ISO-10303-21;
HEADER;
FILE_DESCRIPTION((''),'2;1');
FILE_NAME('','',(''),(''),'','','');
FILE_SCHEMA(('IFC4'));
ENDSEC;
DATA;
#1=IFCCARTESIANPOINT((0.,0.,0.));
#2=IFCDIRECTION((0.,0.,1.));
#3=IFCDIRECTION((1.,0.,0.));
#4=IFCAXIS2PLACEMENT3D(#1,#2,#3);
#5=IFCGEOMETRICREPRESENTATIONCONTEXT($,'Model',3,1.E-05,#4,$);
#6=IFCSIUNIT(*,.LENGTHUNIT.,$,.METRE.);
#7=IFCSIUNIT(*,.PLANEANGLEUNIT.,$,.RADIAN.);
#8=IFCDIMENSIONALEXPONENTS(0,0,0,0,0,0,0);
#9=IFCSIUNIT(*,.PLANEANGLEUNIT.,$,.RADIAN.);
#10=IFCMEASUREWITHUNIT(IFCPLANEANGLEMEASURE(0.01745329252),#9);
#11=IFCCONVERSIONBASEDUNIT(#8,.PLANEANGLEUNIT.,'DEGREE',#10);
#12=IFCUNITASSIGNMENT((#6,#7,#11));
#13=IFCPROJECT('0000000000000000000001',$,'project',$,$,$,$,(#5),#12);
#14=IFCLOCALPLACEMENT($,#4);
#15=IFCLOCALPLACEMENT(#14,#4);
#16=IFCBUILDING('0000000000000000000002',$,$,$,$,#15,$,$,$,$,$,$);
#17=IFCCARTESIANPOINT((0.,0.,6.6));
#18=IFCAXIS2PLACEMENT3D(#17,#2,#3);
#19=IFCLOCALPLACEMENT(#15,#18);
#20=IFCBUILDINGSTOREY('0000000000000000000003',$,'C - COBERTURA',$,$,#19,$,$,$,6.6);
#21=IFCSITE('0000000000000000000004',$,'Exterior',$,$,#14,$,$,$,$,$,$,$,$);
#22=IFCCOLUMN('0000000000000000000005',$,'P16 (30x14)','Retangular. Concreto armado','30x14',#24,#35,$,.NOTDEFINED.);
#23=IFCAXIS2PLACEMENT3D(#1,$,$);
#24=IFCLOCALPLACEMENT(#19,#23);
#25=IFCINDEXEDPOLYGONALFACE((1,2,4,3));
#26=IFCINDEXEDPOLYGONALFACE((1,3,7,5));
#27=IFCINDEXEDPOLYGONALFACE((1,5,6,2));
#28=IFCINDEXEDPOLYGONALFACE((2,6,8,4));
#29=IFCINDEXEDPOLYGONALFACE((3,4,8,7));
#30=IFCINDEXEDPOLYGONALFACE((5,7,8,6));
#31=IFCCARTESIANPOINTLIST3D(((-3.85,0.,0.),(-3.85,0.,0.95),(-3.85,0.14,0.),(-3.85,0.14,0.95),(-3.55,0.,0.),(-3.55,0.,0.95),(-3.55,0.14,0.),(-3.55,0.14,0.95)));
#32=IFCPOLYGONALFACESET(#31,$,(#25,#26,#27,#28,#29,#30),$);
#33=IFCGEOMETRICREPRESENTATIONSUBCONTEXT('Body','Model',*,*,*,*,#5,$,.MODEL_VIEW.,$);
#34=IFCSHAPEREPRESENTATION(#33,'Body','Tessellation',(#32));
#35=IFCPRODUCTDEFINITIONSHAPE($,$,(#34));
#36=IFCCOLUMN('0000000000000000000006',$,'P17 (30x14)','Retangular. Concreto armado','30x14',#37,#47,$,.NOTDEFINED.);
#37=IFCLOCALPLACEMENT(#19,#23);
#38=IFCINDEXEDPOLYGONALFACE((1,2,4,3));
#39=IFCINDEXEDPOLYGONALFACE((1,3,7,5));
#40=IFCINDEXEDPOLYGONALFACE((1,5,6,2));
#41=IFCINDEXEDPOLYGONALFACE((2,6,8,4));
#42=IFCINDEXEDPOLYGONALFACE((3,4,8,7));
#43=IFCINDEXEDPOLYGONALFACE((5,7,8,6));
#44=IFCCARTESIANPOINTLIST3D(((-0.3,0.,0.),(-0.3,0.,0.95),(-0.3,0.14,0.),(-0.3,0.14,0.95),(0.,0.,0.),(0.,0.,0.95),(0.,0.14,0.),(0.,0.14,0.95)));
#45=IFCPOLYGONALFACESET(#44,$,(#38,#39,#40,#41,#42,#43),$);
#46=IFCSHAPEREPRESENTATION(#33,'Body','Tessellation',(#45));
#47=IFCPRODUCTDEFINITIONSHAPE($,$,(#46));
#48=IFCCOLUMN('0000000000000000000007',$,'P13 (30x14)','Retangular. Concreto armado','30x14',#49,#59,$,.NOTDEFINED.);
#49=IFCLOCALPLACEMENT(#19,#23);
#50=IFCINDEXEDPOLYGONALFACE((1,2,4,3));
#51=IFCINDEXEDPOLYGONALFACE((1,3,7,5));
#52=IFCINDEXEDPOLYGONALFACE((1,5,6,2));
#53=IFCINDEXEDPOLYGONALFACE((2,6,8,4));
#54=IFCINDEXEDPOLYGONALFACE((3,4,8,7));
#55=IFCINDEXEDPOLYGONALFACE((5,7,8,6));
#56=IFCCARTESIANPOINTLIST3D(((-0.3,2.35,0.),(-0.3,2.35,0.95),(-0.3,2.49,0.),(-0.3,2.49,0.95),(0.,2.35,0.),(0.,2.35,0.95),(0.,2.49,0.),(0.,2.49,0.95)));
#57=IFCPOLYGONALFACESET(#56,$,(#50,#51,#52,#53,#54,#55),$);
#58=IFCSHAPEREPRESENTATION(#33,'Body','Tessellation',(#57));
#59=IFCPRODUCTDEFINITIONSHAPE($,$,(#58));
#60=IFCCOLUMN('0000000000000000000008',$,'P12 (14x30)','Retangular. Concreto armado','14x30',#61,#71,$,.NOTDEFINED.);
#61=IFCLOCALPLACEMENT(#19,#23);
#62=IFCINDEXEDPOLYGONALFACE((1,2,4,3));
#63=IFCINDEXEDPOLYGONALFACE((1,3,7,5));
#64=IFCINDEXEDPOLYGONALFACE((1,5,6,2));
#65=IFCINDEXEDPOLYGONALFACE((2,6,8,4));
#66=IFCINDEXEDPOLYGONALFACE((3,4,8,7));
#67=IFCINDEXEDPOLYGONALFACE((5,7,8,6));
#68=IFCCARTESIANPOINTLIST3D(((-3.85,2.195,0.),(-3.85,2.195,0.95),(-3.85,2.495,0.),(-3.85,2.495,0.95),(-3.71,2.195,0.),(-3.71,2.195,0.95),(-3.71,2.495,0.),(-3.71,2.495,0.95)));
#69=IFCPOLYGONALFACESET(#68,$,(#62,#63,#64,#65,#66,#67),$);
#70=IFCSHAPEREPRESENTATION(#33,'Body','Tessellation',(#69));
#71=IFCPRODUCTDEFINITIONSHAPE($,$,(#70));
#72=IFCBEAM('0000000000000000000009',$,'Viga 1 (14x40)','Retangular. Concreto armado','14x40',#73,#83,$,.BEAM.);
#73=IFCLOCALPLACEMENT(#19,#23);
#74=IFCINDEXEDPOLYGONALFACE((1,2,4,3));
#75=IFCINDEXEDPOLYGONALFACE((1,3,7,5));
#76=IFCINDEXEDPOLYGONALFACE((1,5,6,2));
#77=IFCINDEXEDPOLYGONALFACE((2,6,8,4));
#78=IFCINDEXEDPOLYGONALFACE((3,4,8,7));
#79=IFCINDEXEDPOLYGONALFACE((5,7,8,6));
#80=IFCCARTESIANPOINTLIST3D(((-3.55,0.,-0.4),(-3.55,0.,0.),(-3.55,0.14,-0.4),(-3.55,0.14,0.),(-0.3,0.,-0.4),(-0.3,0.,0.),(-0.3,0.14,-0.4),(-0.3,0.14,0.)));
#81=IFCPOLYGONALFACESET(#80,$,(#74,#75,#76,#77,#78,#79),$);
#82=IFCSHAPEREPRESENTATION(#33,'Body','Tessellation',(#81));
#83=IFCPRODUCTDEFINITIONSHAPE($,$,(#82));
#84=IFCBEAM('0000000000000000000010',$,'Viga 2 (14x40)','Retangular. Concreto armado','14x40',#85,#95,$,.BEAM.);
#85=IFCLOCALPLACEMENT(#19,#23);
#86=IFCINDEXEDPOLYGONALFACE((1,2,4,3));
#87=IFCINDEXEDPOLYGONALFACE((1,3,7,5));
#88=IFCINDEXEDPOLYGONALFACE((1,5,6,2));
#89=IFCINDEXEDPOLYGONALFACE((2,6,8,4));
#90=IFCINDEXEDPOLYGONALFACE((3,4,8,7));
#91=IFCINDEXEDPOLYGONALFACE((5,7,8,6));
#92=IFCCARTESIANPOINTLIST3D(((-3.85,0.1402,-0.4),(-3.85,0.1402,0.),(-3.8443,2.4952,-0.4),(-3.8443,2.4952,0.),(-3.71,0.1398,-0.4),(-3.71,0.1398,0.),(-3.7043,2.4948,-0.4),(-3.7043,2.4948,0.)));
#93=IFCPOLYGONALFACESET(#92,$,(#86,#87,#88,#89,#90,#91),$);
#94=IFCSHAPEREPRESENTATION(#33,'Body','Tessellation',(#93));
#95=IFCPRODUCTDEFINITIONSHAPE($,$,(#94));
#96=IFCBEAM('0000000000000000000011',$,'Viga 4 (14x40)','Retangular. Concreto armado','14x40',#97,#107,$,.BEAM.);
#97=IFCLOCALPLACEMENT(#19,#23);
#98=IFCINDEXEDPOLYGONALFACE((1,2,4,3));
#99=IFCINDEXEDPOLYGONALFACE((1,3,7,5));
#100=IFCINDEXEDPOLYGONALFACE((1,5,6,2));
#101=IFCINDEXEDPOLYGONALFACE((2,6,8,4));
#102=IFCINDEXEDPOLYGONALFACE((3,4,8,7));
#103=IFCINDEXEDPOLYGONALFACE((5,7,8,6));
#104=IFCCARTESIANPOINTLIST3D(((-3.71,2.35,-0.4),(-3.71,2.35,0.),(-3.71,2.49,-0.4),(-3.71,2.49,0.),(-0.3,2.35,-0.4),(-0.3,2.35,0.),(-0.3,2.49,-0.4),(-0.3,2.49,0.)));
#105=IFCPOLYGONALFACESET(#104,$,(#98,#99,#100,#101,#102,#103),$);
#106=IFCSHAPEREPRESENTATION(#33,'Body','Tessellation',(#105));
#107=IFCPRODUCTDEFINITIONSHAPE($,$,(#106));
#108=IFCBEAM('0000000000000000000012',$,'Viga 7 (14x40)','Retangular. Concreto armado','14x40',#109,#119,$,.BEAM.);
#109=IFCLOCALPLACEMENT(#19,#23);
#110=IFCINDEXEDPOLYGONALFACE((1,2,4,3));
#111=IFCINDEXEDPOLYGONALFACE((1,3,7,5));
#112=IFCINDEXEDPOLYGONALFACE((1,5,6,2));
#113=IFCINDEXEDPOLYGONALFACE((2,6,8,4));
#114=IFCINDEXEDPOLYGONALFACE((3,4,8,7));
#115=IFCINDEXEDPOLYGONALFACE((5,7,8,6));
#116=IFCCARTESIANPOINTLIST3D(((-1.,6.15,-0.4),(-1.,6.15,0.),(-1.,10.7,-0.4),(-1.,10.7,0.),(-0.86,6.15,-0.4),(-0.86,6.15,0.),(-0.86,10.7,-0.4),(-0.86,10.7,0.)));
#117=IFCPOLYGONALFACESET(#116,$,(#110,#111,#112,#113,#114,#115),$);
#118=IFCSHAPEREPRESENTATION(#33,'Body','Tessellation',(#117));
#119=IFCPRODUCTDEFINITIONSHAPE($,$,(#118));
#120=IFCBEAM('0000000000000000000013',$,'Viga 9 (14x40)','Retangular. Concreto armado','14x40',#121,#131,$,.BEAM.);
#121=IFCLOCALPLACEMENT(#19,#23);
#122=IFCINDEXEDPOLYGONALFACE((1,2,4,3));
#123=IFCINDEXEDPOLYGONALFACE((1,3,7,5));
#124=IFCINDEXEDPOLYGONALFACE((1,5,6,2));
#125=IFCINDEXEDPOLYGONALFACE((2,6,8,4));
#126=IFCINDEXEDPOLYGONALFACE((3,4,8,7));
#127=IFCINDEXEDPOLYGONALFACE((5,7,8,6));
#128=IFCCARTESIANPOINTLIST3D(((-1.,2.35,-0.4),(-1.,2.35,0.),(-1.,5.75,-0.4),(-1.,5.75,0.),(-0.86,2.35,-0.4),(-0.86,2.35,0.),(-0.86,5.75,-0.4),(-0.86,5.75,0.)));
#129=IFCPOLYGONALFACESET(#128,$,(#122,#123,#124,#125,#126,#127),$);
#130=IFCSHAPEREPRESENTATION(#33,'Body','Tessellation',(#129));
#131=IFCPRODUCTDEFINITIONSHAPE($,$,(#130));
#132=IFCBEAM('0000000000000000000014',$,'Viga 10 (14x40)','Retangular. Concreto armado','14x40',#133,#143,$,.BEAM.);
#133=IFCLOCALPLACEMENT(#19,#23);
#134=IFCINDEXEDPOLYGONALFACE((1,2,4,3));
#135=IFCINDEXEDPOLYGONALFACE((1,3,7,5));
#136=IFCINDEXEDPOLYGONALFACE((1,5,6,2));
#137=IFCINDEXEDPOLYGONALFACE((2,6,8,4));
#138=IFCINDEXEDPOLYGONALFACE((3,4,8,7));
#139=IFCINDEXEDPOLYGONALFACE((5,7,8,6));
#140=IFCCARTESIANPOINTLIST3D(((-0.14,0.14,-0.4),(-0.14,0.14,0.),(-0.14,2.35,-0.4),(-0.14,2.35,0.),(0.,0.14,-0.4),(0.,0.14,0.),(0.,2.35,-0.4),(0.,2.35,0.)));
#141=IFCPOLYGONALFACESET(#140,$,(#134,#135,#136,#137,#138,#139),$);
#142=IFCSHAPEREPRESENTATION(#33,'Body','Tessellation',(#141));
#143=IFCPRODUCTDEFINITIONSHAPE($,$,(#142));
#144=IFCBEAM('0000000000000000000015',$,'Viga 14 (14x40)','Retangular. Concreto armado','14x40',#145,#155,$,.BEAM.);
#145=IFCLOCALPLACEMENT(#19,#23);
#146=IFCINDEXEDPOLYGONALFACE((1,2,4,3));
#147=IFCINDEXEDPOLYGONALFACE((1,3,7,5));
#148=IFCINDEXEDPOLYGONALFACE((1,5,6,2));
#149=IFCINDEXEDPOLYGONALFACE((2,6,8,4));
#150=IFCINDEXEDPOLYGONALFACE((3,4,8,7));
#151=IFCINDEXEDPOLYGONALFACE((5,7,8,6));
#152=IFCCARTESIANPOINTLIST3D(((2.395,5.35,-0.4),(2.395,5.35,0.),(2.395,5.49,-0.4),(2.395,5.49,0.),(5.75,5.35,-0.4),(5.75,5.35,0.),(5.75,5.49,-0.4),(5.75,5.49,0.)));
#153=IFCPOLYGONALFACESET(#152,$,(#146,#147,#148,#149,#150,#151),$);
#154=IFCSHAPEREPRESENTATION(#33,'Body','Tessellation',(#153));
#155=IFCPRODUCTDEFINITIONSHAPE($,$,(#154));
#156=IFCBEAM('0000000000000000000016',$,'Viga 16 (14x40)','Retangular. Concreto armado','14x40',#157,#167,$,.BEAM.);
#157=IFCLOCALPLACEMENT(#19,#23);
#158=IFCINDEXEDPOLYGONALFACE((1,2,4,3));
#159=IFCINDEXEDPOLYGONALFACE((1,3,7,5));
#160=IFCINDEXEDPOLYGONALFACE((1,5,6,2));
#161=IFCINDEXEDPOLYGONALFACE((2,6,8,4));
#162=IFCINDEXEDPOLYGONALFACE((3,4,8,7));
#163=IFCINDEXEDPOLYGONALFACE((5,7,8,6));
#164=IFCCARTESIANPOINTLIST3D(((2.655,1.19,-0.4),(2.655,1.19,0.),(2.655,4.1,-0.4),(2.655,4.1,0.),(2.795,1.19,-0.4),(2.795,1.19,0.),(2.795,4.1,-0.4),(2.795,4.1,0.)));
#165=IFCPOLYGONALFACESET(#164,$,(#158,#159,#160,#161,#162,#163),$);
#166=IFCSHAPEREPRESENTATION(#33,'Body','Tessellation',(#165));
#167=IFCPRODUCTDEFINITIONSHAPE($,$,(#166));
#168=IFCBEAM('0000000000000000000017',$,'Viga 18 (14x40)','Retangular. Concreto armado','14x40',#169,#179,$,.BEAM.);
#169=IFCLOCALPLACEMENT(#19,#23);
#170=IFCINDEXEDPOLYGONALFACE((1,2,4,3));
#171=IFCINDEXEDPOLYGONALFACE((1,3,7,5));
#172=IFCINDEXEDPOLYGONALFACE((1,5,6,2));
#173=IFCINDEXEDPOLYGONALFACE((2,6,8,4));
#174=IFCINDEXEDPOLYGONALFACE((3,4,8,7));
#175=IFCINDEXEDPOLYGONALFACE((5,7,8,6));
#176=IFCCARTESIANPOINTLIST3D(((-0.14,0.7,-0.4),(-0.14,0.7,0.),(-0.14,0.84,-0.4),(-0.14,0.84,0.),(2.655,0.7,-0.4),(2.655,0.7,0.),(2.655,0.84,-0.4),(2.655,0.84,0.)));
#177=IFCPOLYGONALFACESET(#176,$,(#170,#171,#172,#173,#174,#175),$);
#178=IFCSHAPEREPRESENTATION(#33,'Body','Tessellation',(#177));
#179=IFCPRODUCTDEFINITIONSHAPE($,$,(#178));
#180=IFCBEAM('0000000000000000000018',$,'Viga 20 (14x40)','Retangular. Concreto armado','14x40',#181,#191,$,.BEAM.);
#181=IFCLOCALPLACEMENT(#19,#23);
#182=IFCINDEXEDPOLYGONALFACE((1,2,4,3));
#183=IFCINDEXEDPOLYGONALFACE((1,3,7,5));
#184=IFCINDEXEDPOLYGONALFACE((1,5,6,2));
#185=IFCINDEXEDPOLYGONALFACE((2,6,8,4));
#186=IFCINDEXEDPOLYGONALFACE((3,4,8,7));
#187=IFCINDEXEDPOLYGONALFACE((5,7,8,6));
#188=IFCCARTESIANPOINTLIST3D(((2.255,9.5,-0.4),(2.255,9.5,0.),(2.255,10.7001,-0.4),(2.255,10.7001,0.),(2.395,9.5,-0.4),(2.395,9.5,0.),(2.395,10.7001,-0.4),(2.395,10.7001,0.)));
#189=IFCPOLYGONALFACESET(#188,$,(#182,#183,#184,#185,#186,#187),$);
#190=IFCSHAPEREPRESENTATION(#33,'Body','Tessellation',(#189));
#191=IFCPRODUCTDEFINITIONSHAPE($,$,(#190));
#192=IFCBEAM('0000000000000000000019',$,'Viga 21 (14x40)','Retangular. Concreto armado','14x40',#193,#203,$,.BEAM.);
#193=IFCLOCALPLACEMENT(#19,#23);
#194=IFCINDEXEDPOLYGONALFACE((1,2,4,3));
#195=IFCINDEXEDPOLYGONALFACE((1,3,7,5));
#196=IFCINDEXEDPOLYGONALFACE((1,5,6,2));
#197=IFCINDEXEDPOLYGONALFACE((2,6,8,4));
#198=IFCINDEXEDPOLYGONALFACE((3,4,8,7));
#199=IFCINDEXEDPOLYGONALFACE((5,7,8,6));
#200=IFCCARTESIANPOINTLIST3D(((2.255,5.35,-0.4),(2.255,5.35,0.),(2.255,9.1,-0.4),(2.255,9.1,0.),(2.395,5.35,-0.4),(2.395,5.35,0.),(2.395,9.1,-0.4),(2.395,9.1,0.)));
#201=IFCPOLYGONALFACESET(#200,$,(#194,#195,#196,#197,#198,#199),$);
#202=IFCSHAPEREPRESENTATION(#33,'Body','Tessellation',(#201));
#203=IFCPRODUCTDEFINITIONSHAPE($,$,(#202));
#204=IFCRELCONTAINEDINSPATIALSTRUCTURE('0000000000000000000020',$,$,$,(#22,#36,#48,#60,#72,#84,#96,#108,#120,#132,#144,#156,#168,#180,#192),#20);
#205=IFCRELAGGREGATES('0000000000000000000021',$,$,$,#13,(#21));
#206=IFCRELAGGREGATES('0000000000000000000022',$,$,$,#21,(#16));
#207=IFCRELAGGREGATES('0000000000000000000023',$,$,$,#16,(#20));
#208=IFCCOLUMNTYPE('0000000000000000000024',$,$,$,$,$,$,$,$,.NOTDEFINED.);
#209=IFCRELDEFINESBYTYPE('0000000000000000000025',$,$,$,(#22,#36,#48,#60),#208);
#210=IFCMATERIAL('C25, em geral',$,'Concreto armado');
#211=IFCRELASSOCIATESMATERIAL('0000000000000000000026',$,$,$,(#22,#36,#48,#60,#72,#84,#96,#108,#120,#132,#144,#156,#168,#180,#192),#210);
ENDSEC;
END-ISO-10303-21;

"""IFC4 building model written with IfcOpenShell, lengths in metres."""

from ifc_helpers import new_model, entity, si_unit, converted_unit, frame, frame_2d, origin_with_axes, origin_2d_with_axis, place, context, subcontext, project, spatial, rectangle, extrude, material, type_object, element, save


model = new_model("IFC4")

# Units and contexts
model_context = context("Model", 3, precision=1e-05, world=origin_with_axes())
body_context = subcontext(model_context, "Body", "Model", "MODEL_VIEW")
ifc_project = project(units=[si_unit("LENGTHUNIT", "METRE"), si_unit("PLANEANGLEUNIT", "RADIAN"), converted_unit("PLANEANGLEUNIT", "DEGREE", entity("IfcPlaneAngleMeasure", 0.01745329252), si_unit("PLANEANGLEUNIT", "RADIAN"), dimensions=[0, 0, 0, 0, 0, 0, 0])], contexts=[model_context])

# Site, building, storey
site_placement = place(None, origin_with_axes())
site = spatial("IfcSite", under=ifc_project, at=site_placement, Name="Exterior")
building_placement = place(site_placement, origin_with_axes())
building = spatial("IfcBuilding", under=site, at=building_placement)
storey_placement = place(building_placement, frame((0.0, 0.0, 6.6), z_axis=(0.0, 0.0, 1.0), x_axis=(1.0, 0.0, 0.0)))
storey = spatial("IfcBuildingStorey", under=building, at=storey_placement, Name="C - COBERTURA", Elevation=6.6)

# Columns
ifc_material_1 = material(Name="C25, em geral", Category="Concreto armado")
column_type = type_object("IfcColumnType", PredefinedType="NOTDEFINED")
for number, where, z_axis, x_axis, name in (
    (1, (-3.7, 0.07, 0.0), (0.0, 0.0, 1.0), (1.0, 0.0, 0.0), "P16 (30x14)"),
    (2, (-0.15, 0.07, 0.0), (0.0, 0.0, 1.0), (1.0, 0.0, 0.0), "P17 (30x14)"),
    (3, (-0.15, 2.42, 0.0), (0.0, 0.0, 1.0), (1.0, 0.0, 0.0), "P13 (30x14)"),
):
    element("IfcColumn", number, at=place(storey_placement, frame(where, z_axis=z_axis, x_axis=x_axis)), inside=storey, type_object=column_type, material=ifc_material_1, Name=name, Description="Retangular. Concreto armado", ObjectType="30x14", PredefinedType="NOTDEFINED", context=body_context, shape_type="SweptSolid", body=[
        extrude(rectangle(XDim=0.3, YDim=0.14, at=origin_2d_with_axis()), origin_with_axes(), (0.0, 0.0, 1.0), 0.95),
    ])
column_placement = place(storey_placement, frame((-3.78, 2.345, 0.0), z_axis=(0.0, 0.0, 1.0), x_axis=(1.0, 0.0, 0.0)))
element("IfcColumn", 4, at=column_placement, inside=storey, type_object=column_type, material=ifc_material_1, Name="P12 (14x30)", Description="Retangular. Concreto armado", ObjectType="14x30", PredefinedType="NOTDEFINED", context=body_context, shape_type="SweptSolid", body=[
    extrude(rectangle(XDim=0.14, YDim=0.3, at=origin_2d_with_axis()), origin_with_axes(), (0.0, 0.0, 1.0), 0.95),
])

# Beams
beam_1_placement = place(storey_placement, frame((-3.55, 0.07, 0.0), z_axis=(1.0, 0.0, 0.0), x_axis=(0.0, 1.0, 0.0)))
element("IfcBeam", 5, at=beam_1_placement, inside=storey, material=ifc_material_1, Name="Viga 1 (14x40)", Description="Retangular. Concreto armado", ObjectType="14x40", PredefinedType="BEAM", context=body_context, shape_type="SweptSolid", body=[
    extrude(rectangle(XDim=0.14, YDim=0.4, at=frame_2d((0.0, -0.2), x_axis=(1.0, 0.0))), origin_with_axes(), (0.0, 0.0, 1.0), 3.25),
])
beam_2_placement = place(storey_placement, frame((-3.78, 0.14, 0.0), z_axis=(0.002427, 0.999997, 0.0), x_axis=(-0.999997, 0.002427, 0.0)))
element("IfcBeam", 6, at=beam_2_placement, inside=storey, material=ifc_material_1, Name="Viga 2 (14x40)", Description="Retangular. Concreto armado", ObjectType="14x40", PredefinedType="BEAM", context=body_context, shape_type="SweptSolid", body=[
    extrude(rectangle(XDim=0.14, YDim=0.4, at=frame_2d((0.0, -0.2), x_axis=(1.0, 0.0))), origin_with_axes(), (0.0, 0.0, 1.0), 2.355),
])
beam_3_placement = place(storey_placement, frame((-0.3, 2.42, 0.0), z_axis=(-1.0, 0.0, 0.0), x_axis=(0.0, -1.0, 0.0)))
element("IfcBeam", 7, at=beam_3_placement, inside=storey, material=ifc_material_1, Name="Viga 4 (14x40)", Description="Retangular. Concreto armado", ObjectType="14x40", PredefinedType="BEAM", context=body_context, shape_type="SweptSolid", body=[
    extrude(rectangle(XDim=0.14, YDim=0.4, at=frame_2d((0.0, -0.2), x_axis=(1.0, 0.0))), origin_with_axes(), (0.0, 0.0, 1.0), 3.41),
])
beam_4_placement = place(storey_placement, frame((-0.93, 10.7, 0.0), z_axis=(0.0, -1.0, 0.0), x_axis=(1.0, 0.0, 0.0)))
element("IfcBeam", 8, at=beam_4_placement, inside=storey, material=ifc_material_1, Name="Viga 7 (14x40)", Description="Retangular. Concreto armado", ObjectType="14x40", PredefinedType="BEAM", context=body_context, shape_type="SweptSolid", body=[
    extrude(rectangle(XDim=0.14, YDim=0.4, at=frame_2d((0.0, -0.2), x_axis=(1.0, 0.0))), origin_with_axes(), (0.0, 0.0, 1.0), 4.55),
])
beam_5_placement = place(storey_placement, frame((-0.93, 2.35, 0.0), z_axis=(0.0, 1.0, 0.0), x_axis=(-1.0, 0.0, 0.0)))
element("IfcBeam", 9, at=beam_5_placement, inside=storey, material=ifc_material_1, Name="Viga 9 (14x40)", Description="Retangular. Concreto armado", ObjectType="14x40", PredefinedType="BEAM", context=body_context, shape_type="SweptSolid", body=[
    extrude(rectangle(XDim=0.14, YDim=0.4, at=frame_2d((0.0, -0.2), x_axis=(1.0, 0.0))), origin_with_axes(), (0.0, 0.0, 1.0), 3.4),
])
beam_6_placement = place(storey_placement, frame((-0.07, 0.14, 0.0), z_axis=(0.0, 1.0, 0.0), x_axis=(-1.0, 0.0, 0.0)))
element("IfcBeam", 10, at=beam_6_placement, inside=storey, material=ifc_material_1, Name="Viga 10 (14x40)", Description="Retangular. Concreto armado", ObjectType="14x40", PredefinedType="BEAM", context=body_context, shape_type="SweptSolid", body=[
    extrude(rectangle(XDim=0.14, YDim=0.4, at=frame_2d((0.0, -0.2), x_axis=(1.0, 0.0))), origin_with_axes(), (0.0, 0.0, 1.0), 2.21),
])
beam_7_placement = place(storey_placement, frame((2.395, 5.42, 0.0), z_axis=(1.0, 0.0, 0.0), x_axis=(0.0, 1.0, 0.0)))
element("IfcBeam", 11, at=beam_7_placement, inside=storey, material=ifc_material_1, Name="Viga 14 (14x40)", Description="Retangular. Concreto armado", ObjectType="14x40", PredefinedType="BEAM", context=body_context, shape_type="SweptSolid", body=[
    extrude(rectangle(XDim=0.14, YDim=0.4, at=frame_2d((0.0, -0.2), x_axis=(1.0, 0.0))), origin_with_axes(), (0.0, 0.0, 1.0), 3.355),
])
beam_8_placement = place(storey_placement, frame((2.725, 4.1, 0.0), z_axis=(0.0, -1.0, 0.0), x_axis=(1.0, 0.0, 0.0)))
element("IfcBeam", 12, at=beam_8_placement, inside=storey, material=ifc_material_1, Name="Viga 16 (14x40)", Description="Retangular. Concreto armado", ObjectType="14x40", PredefinedType="BEAM", context=body_context, shape_type="SweptSolid", body=[
    extrude(rectangle(XDim=0.14, YDim=0.4, at=frame_2d((0.0, -0.2), x_axis=(1.0, 0.0))), origin_with_axes(), (0.0, 0.0, 1.0), 2.91),
])
beam_9_placement = place(storey_placement, frame((2.655, 0.77, 0.0), z_axis=(-1.0, 0.0, 0.0), x_axis=(0.0, -1.0, 0.0)))
element("IfcBeam", 13, at=beam_9_placement, inside=storey, material=ifc_material_1, Name="Viga 18 (14x40)", Description="Retangular. Concreto armado", ObjectType="14x40", PredefinedType="BEAM", context=body_context, shape_type="SweptSolid", body=[
    extrude(rectangle(XDim=0.14, YDim=0.4, at=frame_2d((0.0, -0.2), x_axis=(1.0, 0.0))), origin_with_axes(), (0.0, 0.0, 1.0), 2.795),
])
beam_10_placement = place(storey_placement, frame((2.325, 10.7001, 0.0), z_axis=(0.0, -1.0, 0.0), x_axis=(1.0, 0.0, 0.0)))
element("IfcBeam", 14, at=beam_10_placement, inside=storey, material=ifc_material_1, Name="Viga 20 (14x40)", Description="Retangular. Concreto armado", ObjectType="14x40", PredefinedType="BEAM", context=body_context, shape_type="SweptSolid", body=[
    extrude(rectangle(XDim=0.14, YDim=0.4, at=frame_2d((0.0, -0.2), x_axis=(1.0, 0.0))), origin_with_axes(), (0.0, 0.0, 1.0), 1.2001),
])
beam_11_placement = place(storey_placement, frame((2.325, 9.1, 0.0), z_axis=(0.0, -1.0, 0.0), x_axis=(1.0, 0.0, 0.0)))
element("IfcBeam", 15, at=beam_11_placement, inside=storey, material=ifc_material_1, Name="Viga 21 (14x40)", Description="Retangular. Concreto armado", ObjectType="14x40", PredefinedType="BEAM", context=body_context, shape_type="SweptSolid", body=[
    extrude(rectangle(XDim=0.14, YDim=0.4, at=frame_2d((0.0, -0.2), x_axis=(1.0, 0.0))), origin_with_axes(), (0.0, 0.0, 1.0), 3.75),
])

save(model, "model.ifc")
